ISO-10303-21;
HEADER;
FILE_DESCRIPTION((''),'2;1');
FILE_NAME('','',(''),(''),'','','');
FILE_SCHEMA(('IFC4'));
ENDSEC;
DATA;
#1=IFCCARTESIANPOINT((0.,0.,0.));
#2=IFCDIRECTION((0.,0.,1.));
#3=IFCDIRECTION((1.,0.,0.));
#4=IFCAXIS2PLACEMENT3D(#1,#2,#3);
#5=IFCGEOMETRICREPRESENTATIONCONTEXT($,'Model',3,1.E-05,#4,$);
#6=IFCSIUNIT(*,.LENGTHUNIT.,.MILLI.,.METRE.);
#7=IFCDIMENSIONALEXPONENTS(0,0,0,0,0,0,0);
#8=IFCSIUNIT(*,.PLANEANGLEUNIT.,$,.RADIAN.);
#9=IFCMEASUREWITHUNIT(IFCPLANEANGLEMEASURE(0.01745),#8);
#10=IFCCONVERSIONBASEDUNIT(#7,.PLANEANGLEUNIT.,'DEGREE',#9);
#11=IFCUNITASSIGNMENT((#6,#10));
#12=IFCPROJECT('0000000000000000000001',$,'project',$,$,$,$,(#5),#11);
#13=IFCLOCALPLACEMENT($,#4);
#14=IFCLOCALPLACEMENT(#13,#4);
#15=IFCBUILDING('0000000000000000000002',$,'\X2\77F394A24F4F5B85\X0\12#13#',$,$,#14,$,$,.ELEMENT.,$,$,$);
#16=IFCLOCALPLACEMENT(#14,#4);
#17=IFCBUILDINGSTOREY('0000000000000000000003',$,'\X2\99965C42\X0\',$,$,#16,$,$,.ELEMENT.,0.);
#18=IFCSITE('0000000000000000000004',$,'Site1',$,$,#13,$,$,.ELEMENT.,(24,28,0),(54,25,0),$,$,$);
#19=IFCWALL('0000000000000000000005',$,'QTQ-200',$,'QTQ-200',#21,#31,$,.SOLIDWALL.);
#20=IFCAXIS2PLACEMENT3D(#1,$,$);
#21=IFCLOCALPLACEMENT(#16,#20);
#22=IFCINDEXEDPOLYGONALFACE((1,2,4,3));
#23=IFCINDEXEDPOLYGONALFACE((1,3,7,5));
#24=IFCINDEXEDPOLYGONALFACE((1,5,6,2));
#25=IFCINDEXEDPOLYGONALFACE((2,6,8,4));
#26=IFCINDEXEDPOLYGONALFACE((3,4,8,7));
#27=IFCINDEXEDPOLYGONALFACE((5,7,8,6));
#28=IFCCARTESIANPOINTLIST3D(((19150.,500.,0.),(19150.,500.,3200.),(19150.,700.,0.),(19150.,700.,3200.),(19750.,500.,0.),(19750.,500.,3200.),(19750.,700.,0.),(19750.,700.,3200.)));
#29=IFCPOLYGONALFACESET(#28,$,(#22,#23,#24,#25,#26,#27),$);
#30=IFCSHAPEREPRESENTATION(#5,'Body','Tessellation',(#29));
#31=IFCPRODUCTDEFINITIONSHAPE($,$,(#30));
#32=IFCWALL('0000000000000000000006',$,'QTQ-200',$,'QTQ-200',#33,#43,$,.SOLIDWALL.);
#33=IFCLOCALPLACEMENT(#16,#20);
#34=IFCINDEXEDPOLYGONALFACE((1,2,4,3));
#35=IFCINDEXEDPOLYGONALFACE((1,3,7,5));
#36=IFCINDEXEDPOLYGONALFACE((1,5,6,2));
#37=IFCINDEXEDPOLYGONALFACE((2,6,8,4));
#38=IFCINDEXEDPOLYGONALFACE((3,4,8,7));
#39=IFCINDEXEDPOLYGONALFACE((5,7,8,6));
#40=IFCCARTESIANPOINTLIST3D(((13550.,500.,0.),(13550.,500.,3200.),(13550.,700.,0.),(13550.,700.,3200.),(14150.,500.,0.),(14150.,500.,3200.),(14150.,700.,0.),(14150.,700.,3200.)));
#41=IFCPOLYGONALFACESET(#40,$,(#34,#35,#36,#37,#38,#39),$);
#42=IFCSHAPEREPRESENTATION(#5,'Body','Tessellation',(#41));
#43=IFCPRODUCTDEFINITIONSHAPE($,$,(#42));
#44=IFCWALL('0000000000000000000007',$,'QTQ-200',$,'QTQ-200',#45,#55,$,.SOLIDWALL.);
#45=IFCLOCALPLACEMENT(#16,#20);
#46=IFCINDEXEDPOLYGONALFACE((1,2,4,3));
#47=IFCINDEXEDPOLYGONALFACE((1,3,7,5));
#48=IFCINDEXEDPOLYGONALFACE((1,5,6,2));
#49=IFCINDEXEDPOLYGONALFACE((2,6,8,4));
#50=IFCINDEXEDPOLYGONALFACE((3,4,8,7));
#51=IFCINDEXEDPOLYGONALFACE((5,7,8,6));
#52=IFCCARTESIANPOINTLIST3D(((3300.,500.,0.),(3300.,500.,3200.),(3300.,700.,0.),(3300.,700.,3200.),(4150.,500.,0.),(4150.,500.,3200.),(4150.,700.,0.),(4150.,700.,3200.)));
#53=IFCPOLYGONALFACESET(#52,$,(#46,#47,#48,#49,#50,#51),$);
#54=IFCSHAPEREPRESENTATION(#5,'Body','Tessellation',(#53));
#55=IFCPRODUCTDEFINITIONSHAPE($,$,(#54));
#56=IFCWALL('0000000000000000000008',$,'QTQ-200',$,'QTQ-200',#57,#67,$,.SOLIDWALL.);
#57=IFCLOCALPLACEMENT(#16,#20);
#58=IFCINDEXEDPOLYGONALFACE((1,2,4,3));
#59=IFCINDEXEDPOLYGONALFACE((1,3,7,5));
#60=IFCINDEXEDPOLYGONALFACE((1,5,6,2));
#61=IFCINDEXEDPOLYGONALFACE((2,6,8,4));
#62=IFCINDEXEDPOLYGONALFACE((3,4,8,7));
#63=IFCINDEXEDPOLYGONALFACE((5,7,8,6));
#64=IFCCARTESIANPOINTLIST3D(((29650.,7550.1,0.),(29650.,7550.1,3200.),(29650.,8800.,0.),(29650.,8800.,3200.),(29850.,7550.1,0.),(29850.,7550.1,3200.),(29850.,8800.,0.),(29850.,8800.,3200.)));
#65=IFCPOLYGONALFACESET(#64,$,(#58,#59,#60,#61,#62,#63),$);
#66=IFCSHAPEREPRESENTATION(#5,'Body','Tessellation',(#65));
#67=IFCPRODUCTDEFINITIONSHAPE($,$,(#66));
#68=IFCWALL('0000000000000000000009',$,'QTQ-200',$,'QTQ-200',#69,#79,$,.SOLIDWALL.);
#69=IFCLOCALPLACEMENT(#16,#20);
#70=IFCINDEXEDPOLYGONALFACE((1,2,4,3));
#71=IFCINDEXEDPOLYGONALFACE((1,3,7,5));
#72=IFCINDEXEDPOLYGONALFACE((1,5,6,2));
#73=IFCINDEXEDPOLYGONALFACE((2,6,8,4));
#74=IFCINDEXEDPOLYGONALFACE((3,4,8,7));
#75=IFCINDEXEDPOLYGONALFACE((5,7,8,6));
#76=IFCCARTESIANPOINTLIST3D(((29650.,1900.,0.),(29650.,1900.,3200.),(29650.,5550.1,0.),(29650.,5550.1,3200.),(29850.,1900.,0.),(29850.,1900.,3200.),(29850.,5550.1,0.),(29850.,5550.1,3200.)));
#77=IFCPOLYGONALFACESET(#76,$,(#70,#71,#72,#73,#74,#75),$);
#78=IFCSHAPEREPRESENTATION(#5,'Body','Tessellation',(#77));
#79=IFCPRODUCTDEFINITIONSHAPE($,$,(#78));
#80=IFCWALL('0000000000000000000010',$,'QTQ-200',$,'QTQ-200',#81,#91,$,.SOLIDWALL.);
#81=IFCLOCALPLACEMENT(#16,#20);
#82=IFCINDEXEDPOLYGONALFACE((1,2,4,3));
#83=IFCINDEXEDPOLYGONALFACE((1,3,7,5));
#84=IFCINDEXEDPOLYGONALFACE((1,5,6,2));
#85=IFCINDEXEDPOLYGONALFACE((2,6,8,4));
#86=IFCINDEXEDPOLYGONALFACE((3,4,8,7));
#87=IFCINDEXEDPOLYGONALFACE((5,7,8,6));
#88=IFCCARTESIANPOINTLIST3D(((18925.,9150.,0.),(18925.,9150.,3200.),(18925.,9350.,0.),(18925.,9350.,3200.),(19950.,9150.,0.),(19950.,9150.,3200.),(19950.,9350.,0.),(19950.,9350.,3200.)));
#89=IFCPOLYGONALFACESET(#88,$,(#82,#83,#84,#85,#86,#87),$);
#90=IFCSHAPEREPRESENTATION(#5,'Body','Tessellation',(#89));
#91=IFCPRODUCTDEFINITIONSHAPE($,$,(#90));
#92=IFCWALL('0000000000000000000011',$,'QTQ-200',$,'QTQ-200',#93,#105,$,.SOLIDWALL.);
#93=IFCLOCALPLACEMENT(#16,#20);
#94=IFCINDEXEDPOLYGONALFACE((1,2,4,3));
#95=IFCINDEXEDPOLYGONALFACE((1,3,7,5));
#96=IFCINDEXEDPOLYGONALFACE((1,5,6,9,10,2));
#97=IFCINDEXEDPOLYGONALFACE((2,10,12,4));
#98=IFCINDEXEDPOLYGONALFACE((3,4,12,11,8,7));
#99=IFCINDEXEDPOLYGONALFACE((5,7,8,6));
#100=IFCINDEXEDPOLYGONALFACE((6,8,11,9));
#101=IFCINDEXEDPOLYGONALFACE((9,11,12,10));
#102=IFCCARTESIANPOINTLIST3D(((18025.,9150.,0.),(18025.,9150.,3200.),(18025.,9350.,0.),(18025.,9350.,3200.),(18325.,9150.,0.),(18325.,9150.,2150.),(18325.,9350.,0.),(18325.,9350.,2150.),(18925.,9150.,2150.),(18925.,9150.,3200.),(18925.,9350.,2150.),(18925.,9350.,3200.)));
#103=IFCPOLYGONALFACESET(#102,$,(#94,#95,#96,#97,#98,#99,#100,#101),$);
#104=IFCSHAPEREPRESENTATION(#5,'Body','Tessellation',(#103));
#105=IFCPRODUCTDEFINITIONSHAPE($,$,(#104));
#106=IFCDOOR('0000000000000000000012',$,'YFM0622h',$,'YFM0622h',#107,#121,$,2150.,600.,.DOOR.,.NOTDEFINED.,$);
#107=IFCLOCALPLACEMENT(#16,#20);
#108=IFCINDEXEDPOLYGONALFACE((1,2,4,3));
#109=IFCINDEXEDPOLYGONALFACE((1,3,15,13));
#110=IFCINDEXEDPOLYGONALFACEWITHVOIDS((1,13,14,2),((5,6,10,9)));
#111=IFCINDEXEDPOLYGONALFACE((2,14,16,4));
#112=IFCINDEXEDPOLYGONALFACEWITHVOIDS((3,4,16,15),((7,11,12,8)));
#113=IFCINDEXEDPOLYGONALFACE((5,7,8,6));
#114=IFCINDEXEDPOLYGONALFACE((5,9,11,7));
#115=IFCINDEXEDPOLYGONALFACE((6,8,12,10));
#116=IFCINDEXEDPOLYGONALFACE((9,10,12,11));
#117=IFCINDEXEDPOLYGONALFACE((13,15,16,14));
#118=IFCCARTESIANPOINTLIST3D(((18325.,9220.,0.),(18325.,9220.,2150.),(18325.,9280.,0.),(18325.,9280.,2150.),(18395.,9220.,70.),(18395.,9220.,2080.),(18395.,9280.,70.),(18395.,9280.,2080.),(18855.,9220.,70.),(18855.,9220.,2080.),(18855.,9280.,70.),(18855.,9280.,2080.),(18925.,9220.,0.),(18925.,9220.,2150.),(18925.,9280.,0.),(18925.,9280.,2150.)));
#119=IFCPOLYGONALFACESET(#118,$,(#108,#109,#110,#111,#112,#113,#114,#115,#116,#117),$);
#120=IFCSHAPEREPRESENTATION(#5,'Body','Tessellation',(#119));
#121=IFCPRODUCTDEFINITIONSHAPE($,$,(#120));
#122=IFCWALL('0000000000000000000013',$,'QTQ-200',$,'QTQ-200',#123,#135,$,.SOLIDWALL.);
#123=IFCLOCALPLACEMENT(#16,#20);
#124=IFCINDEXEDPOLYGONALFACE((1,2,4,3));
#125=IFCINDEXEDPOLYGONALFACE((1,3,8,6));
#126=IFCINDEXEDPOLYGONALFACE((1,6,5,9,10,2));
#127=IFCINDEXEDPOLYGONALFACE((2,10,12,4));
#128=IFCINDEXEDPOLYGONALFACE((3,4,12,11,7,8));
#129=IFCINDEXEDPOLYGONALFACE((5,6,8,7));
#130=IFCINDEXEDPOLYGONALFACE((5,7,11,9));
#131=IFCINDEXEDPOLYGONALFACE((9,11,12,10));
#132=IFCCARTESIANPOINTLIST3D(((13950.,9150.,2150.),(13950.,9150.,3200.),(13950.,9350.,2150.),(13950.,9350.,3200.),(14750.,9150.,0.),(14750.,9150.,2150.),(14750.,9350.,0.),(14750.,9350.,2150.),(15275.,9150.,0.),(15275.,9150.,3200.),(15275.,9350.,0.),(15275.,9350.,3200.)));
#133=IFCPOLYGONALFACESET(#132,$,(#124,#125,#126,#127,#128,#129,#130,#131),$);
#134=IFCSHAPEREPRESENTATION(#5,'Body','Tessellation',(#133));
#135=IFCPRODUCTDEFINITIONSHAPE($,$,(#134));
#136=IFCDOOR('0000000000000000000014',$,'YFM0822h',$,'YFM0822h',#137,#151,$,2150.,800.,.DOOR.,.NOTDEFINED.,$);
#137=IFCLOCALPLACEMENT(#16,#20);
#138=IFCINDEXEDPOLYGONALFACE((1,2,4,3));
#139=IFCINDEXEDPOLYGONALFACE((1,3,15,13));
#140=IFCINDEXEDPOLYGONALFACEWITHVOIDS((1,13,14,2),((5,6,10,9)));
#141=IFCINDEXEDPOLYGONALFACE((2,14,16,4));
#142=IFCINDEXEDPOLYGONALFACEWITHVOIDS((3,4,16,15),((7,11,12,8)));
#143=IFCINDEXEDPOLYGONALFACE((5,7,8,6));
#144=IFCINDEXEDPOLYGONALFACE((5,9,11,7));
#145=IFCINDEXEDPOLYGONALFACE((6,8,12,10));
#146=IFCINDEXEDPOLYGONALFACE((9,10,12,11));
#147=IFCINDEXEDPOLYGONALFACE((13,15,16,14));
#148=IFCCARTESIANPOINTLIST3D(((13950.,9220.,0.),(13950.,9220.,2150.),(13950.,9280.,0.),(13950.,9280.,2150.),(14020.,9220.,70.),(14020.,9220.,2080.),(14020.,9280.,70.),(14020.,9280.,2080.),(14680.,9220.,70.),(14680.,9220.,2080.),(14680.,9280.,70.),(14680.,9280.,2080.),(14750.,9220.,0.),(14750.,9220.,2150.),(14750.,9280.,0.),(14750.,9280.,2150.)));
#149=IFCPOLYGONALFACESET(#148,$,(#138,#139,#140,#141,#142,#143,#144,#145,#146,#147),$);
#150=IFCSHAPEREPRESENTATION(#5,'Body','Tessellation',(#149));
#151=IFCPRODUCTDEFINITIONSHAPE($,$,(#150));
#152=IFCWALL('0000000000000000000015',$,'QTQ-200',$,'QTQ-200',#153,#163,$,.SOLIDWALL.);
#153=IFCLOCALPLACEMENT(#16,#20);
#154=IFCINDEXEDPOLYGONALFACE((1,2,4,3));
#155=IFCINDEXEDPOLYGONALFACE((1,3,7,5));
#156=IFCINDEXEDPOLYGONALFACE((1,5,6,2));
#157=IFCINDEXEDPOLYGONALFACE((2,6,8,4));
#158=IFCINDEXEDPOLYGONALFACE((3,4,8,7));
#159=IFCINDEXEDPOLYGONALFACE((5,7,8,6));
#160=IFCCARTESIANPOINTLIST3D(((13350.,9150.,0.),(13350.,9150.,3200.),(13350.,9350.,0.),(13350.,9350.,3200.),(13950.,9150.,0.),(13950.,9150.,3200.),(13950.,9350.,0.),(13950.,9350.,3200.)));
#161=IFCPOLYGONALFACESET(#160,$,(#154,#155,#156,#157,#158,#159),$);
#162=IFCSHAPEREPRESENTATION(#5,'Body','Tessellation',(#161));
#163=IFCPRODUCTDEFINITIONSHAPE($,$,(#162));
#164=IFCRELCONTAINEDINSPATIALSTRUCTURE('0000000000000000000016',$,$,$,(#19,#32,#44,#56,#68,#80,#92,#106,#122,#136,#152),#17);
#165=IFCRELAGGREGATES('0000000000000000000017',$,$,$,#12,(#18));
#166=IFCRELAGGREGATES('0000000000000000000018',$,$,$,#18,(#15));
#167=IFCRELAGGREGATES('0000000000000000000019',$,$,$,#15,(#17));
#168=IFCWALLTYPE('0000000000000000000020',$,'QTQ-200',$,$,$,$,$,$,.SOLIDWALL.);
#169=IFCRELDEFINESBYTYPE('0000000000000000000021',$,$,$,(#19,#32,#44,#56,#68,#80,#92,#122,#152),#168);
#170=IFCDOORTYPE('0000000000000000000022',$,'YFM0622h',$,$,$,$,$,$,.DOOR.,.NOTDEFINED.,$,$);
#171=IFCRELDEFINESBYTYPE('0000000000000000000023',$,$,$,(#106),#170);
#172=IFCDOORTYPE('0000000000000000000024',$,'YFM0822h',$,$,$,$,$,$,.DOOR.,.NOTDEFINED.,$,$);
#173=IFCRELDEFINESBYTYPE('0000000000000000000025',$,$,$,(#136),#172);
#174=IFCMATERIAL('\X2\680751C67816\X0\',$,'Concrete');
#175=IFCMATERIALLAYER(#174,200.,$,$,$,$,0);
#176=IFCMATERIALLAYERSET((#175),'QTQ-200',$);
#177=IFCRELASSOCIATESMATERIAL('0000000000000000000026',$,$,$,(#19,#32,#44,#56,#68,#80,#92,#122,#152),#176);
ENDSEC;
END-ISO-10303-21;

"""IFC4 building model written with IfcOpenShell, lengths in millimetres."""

from ifc_helpers import new_model, entity, si_unit, converted_unit, frame, origin_with_axes, place, context, project, spatial, polyline, outline, extrude, material, layer, layer_set, type_object, element, fill, save


model = new_model("IFC4")

# Units and contexts
model_context = context("Model", 3, precision=1e-05, world=origin_with_axes())
ifc_project = project(units=[si_unit("LENGTHUNIT", "METRE", prefix="MILLI"), converted_unit("PLANEANGLEUNIT", "DEGREE", entity("IfcPlaneAngleMeasure", 0.01745), si_unit("PLANEANGLEUNIT", "RADIAN"), dimensions=[0, 0, 0, 0, 0, 0, 0])], contexts=[model_context])

# Site, building, storey
site_placement = place(None, origin_with_axes())
site = spatial("IfcSite", under=ifc_project, at=site_placement, Name="Site1", CompositionType="ELEMENT", RefLatitude=(24, 28, 0), RefLongitude=(54, 25, 0))
building_placement = place(site_placement, origin_with_axes())
building = spatial("IfcBuilding", under=site, at=building_placement, Name="石钢住宅12#13#", CompositionType="ELEMENT")
storey_placement = place(building_placement, origin_with_axes())
storey = spatial("IfcBuildingStorey", under=building, at=storey_placement, Name="首层", CompositionType="ELEMENT", Elevation=0.0)

# Walls
ifc_material_1 = material(Name="标准砖", Category="Concrete")
ifc_layer_1 = layer(ifc_material_1, 200.0, Priority=0)
ifc_layer_set_1 = layer_set([ifc_layer_1], Name="QTQ-200")
wall_type_1 = type_object("IfcWallType", Name="QTQ-200", PredefinedType="SOLIDWALL")
wall_1_placement = place(storey_placement, origin_with_axes())
element("IfcWall", 1, at=wall_1_placement, inside=storey, type_object=wall_type_1, material=ifc_layer_set_1, Name="QTQ-200", ObjectType="QTQ-200", PredefinedType="SOLIDWALL", context=model_context, shape_type="SweptSolid", body=[
    extrude(outline(polyline([(0.0, 0.0), (3200.0, 0.0), (3200.0, 600.0), (0.0, 600.0), (0.0, 0.0)])), frame((19150.0, 700.0, 3200.0), z_axis=(0.0, -1.0, 0.0), x_axis=(0.0, 0.0, -1.0)), (0.0, 0.0, 1.0), 200.0),
])
wall_2_placement = place(storey_placement, origin_with_axes())
element("IfcWall", 2, at=wall_2_placement, inside=storey, type_object=wall_type_1, material=ifc_layer_set_1, Name="QTQ-200", ObjectType="QTQ-200", PredefinedType="SOLIDWALL", context=model_context, shape_type="SweptSolid", body=[
    extrude(outline(polyline([(0.0, 0.0), (3200.0, 0.0), (3200.0, 600.0), (0.0, 600.0), (0.0, 0.0)])), frame((13550.0, 700.0, 3200.0), z_axis=(0.0, -1.0, 0.0), x_axis=(0.0, 0.0, -1.0)), (0.0, 0.0, 1.0), 200.0),
])
wall_3_placement = place(storey_placement, origin_with_axes())
element("IfcWall", 3, at=wall_3_placement, inside=storey, type_object=wall_type_1, material=ifc_layer_set_1, Name="QTQ-200", ObjectType="QTQ-200", PredefinedType="SOLIDWALL", context=model_context, shape_type="SweptSolid", body=[
    extrude(outline(polyline([(0.0, 0.0), (3200.0, 0.0), (3200.0, 850.0), (0.0, 850.0), (0.0, 0.0)])), frame((3300.0, 700.0, 3200.0), z_axis=(0.0, -1.0, 0.0), x_axis=(0.0, 0.0, -1.0)), (0.0, 0.0, 1.0), 200.0),
])
wall_4_placement = place(storey_placement, origin_with_axes())
element("IfcWall", 4, at=wall_4_placement, inside=storey, type_object=wall_type_1, material=ifc_layer_set_1, Name="QTQ-200", ObjectType="QTQ-200", PredefinedType="SOLIDWALL", context=model_context, shape_type="SweptSolid", body=[
    extrude(outline(polyline([(0.0, 0.0), (3200.0, 0.0), (3200.0, 1249.9), (0.0, 1249.9), (0.0, 0.0)])), frame((29650.0, 7550.1, 3200.0), z_axis=(1.0, 0.0, 0.0), x_axis=(0.0, 0.0, -1.0)), (0.0, 0.0, 1.0), 200.0),
])
wall_5_placement = place(storey_placement, origin_with_axes())
element("IfcWall", 5, at=wall_5_placement, inside=storey, type_object=wall_type_1, material=ifc_layer_set_1, Name="QTQ-200", ObjectType="QTQ-200", PredefinedType="SOLIDWALL", context=model_context, shape_type="SweptSolid", body=[
    extrude(outline(polyline([(0.0, 0.0), (3200.0, 0.0), (3200.0, 3650.1), (0.0, 3650.1), (0.0, 0.0)])), frame((29650.0, 1900.0, 3200.0), z_axis=(1.0, 0.0, 0.0), x_axis=(0.0, 0.0, -1.0)), (0.0, 0.0, 1.0), 200.0),
])
wall_6_placement = place(storey_placement, origin_with_axes())
element("IfcWall", 6, at=wall_6_placement, inside=storey, type_object=wall_type_1, material=ifc_layer_set_1, Name="QTQ-200", ObjectType="QTQ-200", PredefinedType="SOLIDWALL", context=model_context, shape_type="SweptSolid", body=[
    extrude(outline(polyline([(0.0, 0.0), (3200.0, 0.0), (3200.0, 1025.0), (0.0, 1025.0), (0.0, 0.0)])), frame((18925.0, 9350.0, 3200.0), z_axis=(0.0, -1.0, 0.0), x_axis=(0.0, 0.0, -1.0)), (0.0, 0.0, 1.0), 200.0),
])

# Walls, openings, doors
wall_7_placement = place(storey_placement, origin_with_axes())
wall_7 = element("IfcWall", 7, at=wall_7_placement, inside=storey, type_object=wall_type_1, material=ifc_layer_set_1, Name="QTQ-200", ObjectType="QTQ-200", PredefinedType="SOLIDWALL", context=model_context, shape_type="SweptSolid", body=[
    extrude(outline(polyline([(0.0, 0.0), (3200.0, 0.0), (3200.0, 900.0), (0.0, 900.0), (0.0, 0.0)])), frame((18025.0, 9350.0, 3200.0), z_axis=(0.0, -1.0, 0.0), x_axis=(0.0, 0.0, -1.0)), (0.0, 0.0, 1.0), 200.0),
])
opening_1_placement = place(storey_placement, origin_with_axes())
opening_1 = element("IfcOpeningElement", 8, at=opening_1_placement, cuts=wall_7, PredefinedType="OPENING", context=model_context, shape_type="SweptSolid", body=[
    extrude(outline(polyline([(0.0, 0.0), (600.0, 0.0), (600.0, 2150.0), (0.0, 2150.0), (0.0, 0.0)])), frame((18325.0, 10350.0, 0.0), z_axis=(0.0, -1.0, 0.0), x_axis=(1.0, 0.0, 0.0)), (0.0, 0.0, 1.0), 2200.0),
])
door_type_1 = type_object("IfcDoorType", Name="YFM0622h", OperationType="NOTDEFINED", PredefinedType="DOOR")
door_1_placement = place(storey_placement, origin_with_axes())
door_1 = element("IfcDoor", 9, at=door_1_placement, inside=storey, type_object=door_type_1, Name="YFM0622h", ObjectType="YFM0622h", OperationType="NOTDEFINED", OverallHeight=2150.0, OverallWidth=600.0, PredefinedType="DOOR", context=model_context, shape_type="SweptSolid", body=[
    extrude(outline(polyline([(-300.0, -1075.0), (300.0, -1075.0), (300.0, 1075.0), (-300.0, 1075.0), (-300.0, -1075.0)]), holes=[polyline([(-230.0, -1005.0), (-230.0, 1005.0), (230.0, 1005.0), (230.0, -1005.0), (-230.0, -1005.0)])]), frame((18625.0, 9280.0, 1075.0), z_axis=(0.0, -1.0, 0.0), x_axis=(1.0, 0.0, 0.0)), (0.0, 0.0, 1.0), 60.0),
])
fill(opening_1, door_1)
wall_8_placement = place(storey_placement, origin_with_axes())
wall_8 = element("IfcWall", 10, at=wall_8_placement, inside=storey, type_object=wall_type_1, material=ifc_layer_set_1, Name="QTQ-200", ObjectType="QTQ-200", PredefinedType="SOLIDWALL", context=model_context, shape_type="SweptSolid", body=[
    extrude(outline(polyline([(0.0, 0.0), (3200.0, 0.0), (3200.0, 1325.0), (0.0, 1325.0), (0.0, 0.0)])), frame((13950.0, 9350.0, 3200.0), z_axis=(0.0, -1.0, 0.0), x_axis=(0.0, 0.0, -1.0)), (0.0, 0.0, 1.0), 200.0),
])
opening_2_placement = place(storey_placement, origin_with_axes())
opening_2 = element("IfcOpeningElement", 11, at=opening_2_placement, cuts=wall_8, PredefinedType="OPENING", context=model_context, shape_type="SweptSolid", body=[
    extrude(outline(polyline([(0.0, 0.0), (800.0, 0.0), (800.0, 2150.0), (0.0, 2150.0), (0.0, 0.0)])), frame((13950.0, 10350.0, 0.0), z_axis=(0.0, -1.0, 0.0), x_axis=(1.0, 0.0, 0.0)), (0.0, 0.0, 1.0), 2200.0),
])
door_type_2 = type_object("IfcDoorType", Name="YFM0822h", OperationType="NOTDEFINED", PredefinedType="DOOR")
door_2_placement = place(storey_placement, origin_with_axes())
door_2 = element("IfcDoor", 12, at=door_2_placement, inside=storey, type_object=door_type_2, Name="YFM0822h", ObjectType="YFM0822h", OperationType="NOTDEFINED", OverallHeight=2150.0, OverallWidth=800.0, PredefinedType="DOOR", context=model_context, shape_type="SweptSolid", body=[
    extrude(outline(polyline([(-400.0, -1075.0), (400.0, -1075.0), (400.0, 1075.0), (-400.0, 1075.0), (-400.0, -1075.0)]), holes=[polyline([(-330.0, -1005.0), (-330.0, 1005.0), (330.0, 1005.0), (330.0, -1005.0), (-330.0, -1005.0)])]), frame((14350.0, 9280.0, 1075.0), z_axis=(0.0, -1.0, 0.0), x_axis=(1.0, 0.0, 0.0)), (0.0, 0.0, 1.0), 60.0),
])
fill(opening_2, door_2)

# Wall
wall_9_placement = place(storey_placement, origin_with_axes())
element("IfcWall", 13, at=wall_9_placement, inside=storey, type_object=wall_type_1, material=ifc_layer_set_1, Name="QTQ-200", ObjectType="QTQ-200", PredefinedType="SOLIDWALL", context=model_context, shape_type="SweptSolid", body=[
    extrude(outline(polyline([(0.0, 0.0), (3200.0, 0.0), (3200.0, 600.0), (0.0, 600.0), (0.0, 0.0)])), frame((13350.0, 9350.0, 3200.0), z_axis=(0.0, -1.0, 0.0), x_axis=(0.0, 0.0, -1.0)), (0.0, 0.0, 1.0), 200.0),
])

save(model, "model.ifc")
